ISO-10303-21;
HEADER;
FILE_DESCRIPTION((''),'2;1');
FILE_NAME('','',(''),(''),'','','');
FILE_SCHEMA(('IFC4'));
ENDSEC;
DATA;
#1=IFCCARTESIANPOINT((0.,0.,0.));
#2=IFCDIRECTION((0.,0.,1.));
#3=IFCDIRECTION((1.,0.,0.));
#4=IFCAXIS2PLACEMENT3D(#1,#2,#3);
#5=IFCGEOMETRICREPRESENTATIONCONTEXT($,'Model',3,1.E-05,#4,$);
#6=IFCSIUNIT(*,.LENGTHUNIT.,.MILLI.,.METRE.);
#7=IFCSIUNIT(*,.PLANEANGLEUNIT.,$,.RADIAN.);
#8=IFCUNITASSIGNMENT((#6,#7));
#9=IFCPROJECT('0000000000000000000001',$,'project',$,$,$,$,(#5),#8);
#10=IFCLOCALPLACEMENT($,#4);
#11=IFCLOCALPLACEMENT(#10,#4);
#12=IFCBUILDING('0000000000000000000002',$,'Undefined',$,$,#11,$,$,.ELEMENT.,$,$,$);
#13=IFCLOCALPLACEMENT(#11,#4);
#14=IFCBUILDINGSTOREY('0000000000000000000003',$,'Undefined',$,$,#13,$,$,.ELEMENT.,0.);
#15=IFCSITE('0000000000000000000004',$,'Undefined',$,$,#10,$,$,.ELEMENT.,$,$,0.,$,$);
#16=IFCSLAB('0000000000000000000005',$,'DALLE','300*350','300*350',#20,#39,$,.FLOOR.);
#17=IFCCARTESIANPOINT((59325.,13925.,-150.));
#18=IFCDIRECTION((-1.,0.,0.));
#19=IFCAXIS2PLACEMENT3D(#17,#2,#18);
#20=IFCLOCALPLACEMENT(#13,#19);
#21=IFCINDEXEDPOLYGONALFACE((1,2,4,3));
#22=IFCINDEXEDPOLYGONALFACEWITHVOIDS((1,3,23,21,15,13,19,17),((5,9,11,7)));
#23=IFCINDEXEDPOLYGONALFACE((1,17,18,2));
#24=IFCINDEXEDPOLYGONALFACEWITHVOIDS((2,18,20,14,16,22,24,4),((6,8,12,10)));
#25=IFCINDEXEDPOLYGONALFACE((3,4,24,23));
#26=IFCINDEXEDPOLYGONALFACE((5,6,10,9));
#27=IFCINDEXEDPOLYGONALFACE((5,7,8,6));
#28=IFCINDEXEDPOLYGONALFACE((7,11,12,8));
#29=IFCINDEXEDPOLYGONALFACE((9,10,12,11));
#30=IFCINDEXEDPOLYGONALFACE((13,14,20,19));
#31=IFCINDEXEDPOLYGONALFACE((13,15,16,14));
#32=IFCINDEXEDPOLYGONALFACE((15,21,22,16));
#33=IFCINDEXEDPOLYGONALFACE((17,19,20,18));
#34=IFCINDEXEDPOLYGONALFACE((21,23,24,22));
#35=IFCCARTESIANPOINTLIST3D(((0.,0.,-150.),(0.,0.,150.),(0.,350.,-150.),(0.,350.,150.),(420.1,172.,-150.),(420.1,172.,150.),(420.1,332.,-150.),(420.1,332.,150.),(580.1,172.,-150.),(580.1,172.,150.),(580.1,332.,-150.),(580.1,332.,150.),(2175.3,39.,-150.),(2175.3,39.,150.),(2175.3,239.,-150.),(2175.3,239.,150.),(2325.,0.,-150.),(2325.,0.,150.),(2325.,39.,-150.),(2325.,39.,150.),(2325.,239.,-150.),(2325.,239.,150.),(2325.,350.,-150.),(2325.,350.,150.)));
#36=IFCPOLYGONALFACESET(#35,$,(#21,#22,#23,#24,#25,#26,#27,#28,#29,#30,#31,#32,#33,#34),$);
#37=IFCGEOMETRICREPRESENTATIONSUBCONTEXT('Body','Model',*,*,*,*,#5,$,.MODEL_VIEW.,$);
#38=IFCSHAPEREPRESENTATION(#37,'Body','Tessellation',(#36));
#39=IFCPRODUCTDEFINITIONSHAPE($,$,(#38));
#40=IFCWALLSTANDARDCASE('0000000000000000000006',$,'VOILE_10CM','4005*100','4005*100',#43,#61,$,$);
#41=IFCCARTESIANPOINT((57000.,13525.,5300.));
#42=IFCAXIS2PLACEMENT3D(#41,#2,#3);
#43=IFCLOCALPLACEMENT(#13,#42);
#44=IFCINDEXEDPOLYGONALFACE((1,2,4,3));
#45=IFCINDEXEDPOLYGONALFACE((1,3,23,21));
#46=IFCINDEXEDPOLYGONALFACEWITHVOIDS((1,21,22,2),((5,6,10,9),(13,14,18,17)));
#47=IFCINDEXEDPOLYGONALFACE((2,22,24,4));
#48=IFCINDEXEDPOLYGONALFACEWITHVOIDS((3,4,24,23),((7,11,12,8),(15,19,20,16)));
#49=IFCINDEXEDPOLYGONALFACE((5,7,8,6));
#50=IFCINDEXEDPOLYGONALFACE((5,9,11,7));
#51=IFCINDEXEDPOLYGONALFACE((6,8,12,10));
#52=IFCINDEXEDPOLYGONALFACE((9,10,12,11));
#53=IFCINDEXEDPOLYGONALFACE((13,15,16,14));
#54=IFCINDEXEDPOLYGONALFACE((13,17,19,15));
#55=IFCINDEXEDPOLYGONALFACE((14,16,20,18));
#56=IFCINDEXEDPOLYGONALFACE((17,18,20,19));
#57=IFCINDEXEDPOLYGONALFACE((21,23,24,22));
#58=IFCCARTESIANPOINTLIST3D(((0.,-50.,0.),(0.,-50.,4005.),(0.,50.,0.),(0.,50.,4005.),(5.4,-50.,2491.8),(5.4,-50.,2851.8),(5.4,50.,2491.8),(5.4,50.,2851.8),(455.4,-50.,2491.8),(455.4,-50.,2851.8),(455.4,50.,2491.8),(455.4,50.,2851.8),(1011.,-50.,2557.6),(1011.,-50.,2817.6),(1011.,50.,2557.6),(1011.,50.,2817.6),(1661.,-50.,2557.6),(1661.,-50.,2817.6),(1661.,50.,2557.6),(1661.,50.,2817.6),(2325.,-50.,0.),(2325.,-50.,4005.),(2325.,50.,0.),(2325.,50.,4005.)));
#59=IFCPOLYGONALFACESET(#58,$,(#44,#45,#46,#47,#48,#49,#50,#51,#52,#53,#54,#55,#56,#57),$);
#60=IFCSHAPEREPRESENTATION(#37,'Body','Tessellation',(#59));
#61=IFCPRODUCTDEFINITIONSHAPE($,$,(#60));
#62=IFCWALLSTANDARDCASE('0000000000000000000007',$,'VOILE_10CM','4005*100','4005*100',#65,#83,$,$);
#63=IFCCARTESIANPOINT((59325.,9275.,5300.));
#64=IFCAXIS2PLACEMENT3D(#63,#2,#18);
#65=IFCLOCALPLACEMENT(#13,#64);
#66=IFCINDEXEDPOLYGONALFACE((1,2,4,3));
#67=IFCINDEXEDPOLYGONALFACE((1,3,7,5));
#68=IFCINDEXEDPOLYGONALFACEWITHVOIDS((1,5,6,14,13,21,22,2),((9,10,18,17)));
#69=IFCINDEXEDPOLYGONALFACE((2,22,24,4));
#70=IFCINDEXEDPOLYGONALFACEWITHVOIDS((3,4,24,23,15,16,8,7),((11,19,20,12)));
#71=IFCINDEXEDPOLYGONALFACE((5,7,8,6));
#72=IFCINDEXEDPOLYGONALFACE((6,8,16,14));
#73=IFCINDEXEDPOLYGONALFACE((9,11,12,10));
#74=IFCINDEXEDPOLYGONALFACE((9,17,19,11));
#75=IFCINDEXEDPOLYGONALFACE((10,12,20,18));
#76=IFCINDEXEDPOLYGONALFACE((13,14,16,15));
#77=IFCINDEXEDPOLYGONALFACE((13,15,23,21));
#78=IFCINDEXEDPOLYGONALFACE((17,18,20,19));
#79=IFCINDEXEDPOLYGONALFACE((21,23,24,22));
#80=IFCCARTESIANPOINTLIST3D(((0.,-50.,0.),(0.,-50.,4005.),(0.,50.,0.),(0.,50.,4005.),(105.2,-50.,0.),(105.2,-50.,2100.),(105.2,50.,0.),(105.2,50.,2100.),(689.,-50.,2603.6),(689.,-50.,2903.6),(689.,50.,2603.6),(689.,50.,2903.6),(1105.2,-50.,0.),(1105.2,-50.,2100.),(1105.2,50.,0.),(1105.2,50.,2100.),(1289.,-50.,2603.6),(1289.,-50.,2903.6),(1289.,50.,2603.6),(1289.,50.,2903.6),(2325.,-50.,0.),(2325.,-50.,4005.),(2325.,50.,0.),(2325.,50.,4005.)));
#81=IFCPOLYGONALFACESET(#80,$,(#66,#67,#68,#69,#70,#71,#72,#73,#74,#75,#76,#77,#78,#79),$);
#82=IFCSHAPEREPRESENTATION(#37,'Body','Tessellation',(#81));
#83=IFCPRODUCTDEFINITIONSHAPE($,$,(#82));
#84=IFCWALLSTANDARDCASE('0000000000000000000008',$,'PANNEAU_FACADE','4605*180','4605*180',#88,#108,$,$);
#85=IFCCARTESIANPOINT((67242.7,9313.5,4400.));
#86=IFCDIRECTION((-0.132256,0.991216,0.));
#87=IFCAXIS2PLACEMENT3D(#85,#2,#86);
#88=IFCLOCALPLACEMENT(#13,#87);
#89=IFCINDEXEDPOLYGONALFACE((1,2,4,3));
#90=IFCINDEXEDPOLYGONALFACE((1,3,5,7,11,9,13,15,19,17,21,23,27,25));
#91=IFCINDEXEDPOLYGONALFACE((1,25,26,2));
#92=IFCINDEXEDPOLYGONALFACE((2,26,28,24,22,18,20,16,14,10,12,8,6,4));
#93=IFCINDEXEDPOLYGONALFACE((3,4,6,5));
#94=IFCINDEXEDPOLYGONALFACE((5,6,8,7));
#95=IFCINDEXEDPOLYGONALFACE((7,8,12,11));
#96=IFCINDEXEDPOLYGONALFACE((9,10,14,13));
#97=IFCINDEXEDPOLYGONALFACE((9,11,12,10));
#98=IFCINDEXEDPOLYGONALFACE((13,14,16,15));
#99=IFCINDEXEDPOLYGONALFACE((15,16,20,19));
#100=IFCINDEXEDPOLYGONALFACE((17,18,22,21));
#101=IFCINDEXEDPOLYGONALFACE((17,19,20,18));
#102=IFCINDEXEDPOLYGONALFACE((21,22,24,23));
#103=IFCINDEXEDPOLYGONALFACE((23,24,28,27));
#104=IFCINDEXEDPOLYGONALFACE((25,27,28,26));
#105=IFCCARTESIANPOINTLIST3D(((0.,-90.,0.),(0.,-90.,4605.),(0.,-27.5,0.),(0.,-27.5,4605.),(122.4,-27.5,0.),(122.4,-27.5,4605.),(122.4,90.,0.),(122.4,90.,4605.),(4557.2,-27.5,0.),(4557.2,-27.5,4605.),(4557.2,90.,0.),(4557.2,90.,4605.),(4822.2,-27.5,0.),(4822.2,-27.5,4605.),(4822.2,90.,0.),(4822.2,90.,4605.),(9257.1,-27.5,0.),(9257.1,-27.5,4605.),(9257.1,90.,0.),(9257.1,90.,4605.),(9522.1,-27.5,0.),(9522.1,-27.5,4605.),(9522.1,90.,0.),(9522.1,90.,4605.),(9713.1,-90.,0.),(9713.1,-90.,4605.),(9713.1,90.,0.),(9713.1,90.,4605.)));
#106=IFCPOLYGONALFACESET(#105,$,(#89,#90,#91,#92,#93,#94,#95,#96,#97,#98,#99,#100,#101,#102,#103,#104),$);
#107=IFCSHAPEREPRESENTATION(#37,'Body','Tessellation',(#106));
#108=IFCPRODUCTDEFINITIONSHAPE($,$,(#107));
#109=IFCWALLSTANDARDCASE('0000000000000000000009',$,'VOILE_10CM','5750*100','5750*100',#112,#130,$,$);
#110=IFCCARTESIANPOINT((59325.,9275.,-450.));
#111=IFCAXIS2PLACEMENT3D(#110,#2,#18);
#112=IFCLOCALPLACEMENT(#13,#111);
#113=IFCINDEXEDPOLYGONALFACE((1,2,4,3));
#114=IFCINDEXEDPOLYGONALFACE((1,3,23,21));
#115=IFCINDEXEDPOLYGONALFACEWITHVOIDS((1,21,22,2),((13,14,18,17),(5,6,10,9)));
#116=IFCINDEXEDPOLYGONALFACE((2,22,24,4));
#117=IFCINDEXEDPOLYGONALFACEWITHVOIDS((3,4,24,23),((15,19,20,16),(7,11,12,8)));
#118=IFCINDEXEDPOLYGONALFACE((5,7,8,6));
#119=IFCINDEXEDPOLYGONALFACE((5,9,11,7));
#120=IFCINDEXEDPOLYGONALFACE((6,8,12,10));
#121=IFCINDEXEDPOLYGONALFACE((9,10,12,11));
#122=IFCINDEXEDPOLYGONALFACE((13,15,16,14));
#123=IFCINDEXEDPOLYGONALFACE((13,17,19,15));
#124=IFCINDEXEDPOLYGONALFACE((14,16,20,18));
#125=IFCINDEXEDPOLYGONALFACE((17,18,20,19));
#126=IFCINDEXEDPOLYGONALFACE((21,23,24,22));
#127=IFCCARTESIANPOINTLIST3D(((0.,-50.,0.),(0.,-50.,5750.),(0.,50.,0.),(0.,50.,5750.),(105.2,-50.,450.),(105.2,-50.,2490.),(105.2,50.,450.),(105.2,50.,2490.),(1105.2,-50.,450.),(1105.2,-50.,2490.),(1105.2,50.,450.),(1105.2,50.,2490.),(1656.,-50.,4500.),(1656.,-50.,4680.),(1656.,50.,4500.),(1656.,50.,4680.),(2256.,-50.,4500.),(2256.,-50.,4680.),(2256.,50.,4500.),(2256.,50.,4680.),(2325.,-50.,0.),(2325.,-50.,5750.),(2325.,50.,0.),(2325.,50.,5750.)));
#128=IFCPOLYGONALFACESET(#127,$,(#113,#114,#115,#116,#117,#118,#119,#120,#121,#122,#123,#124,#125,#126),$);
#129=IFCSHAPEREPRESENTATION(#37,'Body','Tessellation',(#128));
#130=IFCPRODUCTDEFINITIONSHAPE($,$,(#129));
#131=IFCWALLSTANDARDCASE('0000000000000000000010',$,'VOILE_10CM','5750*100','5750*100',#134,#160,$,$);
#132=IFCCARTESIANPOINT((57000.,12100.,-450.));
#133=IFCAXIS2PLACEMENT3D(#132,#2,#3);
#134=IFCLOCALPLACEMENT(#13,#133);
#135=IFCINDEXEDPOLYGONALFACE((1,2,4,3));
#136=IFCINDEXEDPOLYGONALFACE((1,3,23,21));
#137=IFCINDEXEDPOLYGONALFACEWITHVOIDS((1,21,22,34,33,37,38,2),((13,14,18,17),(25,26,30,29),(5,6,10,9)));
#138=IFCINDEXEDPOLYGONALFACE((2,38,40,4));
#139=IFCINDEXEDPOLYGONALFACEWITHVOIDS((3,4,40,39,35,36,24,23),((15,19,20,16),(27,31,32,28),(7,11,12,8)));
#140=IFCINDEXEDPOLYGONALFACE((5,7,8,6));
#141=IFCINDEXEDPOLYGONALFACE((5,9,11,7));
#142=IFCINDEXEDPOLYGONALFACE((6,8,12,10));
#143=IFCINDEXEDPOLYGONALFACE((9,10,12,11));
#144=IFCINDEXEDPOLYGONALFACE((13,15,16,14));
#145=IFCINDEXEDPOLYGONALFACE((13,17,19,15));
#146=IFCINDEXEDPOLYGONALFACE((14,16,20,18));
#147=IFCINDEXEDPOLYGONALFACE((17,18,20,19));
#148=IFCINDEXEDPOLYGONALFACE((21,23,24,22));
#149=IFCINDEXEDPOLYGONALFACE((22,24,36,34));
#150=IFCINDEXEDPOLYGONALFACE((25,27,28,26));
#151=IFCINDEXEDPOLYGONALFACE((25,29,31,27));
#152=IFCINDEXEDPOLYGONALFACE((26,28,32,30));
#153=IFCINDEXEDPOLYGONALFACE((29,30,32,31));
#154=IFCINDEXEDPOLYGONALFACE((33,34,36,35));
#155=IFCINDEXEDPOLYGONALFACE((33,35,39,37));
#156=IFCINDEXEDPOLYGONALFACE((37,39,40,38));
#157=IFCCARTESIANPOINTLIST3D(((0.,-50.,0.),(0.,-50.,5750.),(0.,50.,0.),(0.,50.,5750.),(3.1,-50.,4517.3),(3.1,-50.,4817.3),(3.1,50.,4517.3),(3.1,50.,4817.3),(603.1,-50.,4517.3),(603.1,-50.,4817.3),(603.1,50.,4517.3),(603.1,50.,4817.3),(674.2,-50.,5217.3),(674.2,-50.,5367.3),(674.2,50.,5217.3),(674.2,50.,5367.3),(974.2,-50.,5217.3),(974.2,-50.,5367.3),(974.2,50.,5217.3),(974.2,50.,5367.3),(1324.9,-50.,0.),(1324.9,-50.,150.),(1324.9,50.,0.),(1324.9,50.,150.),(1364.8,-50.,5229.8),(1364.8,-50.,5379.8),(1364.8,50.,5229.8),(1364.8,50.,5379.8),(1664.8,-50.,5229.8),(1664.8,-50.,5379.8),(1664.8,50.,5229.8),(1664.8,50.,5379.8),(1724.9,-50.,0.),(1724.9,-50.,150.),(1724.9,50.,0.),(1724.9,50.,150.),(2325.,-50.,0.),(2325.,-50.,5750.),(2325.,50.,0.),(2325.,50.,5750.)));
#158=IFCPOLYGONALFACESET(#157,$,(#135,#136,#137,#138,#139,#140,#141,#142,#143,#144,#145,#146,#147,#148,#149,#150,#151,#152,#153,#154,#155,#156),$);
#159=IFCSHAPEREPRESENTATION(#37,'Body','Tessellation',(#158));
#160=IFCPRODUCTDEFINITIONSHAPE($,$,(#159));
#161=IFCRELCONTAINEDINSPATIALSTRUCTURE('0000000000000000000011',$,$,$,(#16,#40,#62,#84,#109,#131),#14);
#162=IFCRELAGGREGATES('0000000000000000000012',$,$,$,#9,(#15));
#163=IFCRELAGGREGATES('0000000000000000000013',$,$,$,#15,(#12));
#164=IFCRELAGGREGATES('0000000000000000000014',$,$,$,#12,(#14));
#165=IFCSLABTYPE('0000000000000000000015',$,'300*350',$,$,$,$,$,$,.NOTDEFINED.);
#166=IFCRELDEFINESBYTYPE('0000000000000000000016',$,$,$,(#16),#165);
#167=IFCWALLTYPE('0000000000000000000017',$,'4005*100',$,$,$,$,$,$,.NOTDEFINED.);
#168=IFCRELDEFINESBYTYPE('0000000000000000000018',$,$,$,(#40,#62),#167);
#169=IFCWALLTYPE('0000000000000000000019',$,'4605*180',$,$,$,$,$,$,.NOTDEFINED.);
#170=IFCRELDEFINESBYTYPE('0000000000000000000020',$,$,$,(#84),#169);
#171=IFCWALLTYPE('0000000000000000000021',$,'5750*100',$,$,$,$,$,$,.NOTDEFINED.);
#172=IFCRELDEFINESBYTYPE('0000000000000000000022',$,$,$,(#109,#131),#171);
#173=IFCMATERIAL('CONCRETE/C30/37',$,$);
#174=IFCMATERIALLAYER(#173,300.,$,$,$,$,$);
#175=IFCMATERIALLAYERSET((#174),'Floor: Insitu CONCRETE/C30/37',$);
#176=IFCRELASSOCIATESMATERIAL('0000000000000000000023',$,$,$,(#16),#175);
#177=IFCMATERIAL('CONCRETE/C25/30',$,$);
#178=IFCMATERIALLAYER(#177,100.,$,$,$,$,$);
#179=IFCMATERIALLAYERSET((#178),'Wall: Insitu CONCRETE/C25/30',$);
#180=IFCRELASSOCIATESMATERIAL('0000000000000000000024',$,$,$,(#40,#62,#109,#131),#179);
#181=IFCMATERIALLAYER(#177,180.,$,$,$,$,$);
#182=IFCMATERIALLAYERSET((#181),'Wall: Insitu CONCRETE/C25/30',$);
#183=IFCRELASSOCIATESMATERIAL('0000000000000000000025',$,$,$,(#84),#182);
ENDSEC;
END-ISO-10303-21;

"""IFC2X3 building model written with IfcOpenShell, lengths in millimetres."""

from ifc_helpers import new_model, si_unit, frame, frame_2d, origin_with_axes, origin_2d_with_axis, place, context, subcontext, project, spatial, polyline, rectangle, outline, extrude, boolean, material, layer, layer_set, layer_usage, type_object, element, save


model = new_model("IFC2X3")

# Units and contexts
model_context = context("Model", 3, precision=1e-05, world=origin_with_axes())
body_context = subcontext(model_context, "Body", "Model", "MODEL_VIEW")
ifc_project = project(units=[si_unit("LENGTHUNIT", "METRE", prefix="MILLI"), si_unit("PLANEANGLEUNIT", "RADIAN")], contexts=[model_context])

# Site, building, storey
site_placement = place(None, origin_with_axes())
site = spatial("IfcSite", under=ifc_project, at=site_placement, Name="Undefined", CompositionType="ELEMENT", RefElevation=0.0)
building_placement = place(site_placement, origin_with_axes())
building = spatial("IfcBuilding", under=site, at=building_placement, Name="Undefined", CompositionType="ELEMENT")
storey_placement = place(building_placement, origin_with_axes())
storey = spatial("IfcBuildingStorey", under=building, at=storey_placement, Name="Undefined", CompositionType="ELEMENT", Elevation=0.0)

# Shared definitions
ifc_material_1 = material(Name="CONCRETE/C25/30")

# Slab
ifc_material_2 = material(Name="CONCRETE/C30/37")
ifc_layer_1 = layer(ifc_material_2, 300.0)
ifc_layer_set_1 = layer_set([ifc_layer_1], Name="Floor: Insitu CONCRETE/C30/37")
ifc_layer_usage_1 = layer_usage(ifc_layer_set_1, "AXIS3", "POSITIVE", -150.0)
slab_type_1 = type_object("IfcSlabType", Name="300*350", PredefinedType="NOTDEFINED")
slab_1_placement = place(storey_placement, frame((59325.0, 13925.0, -150.0), z_axis=(0.0, 0.0, 1.0), x_axis=(-1.0, 0.0, 0.0)))
element("IfcSlab", 1, at=slab_1_placement, inside=storey, type_object=slab_type_1, material=ifc_layer_usage_1, Name="DALLE", Description="300*350", ObjectType="300*350", PredefinedType="FLOOR", context=body_context, shape_type="CSG", body=[
    boolean("DIFFERENCE", boolean("DIFFERENCE", extrude(outline(polyline([(0.0, 0.0), (2325.0, 0.0), (2325.0, 350.0), (0.0, 350.0), (0.0, 0.0)])), frame((0.0, 0.0, -150.0), z_axis=(0.0, 0.0, 1.0), x_axis=(1.0, 0.0, 0.0)), (0.0, 0.0, 1.0), 300.0), extrude(rectangle(XDim=160.0, YDim=160.0, at=origin_2d_with_axis()), frame((500.1, 252.0, 160.0), z_axis=(0.0, 0.0, -1.0), x_axis=(-1.0, 0.0, 0.0)), (0.0, 0.0, 1.0), 320.0)), extrude(rectangle(XDim=150.0, YDim=200.0, at=origin_2d_with_axis()), frame((2250.3, 139.0, 160.0), z_axis=(0.0, 0.0, -1.0), x_axis=(-1.0, 0.0, 0.0)), (0.0, 0.0, 1.0), 320.0)),
])

# Walls
ifc_layer_2 = layer(ifc_material_1, 180.0)
ifc_layer_set_2 = layer_set([ifc_layer_2], Name="Wall: Insitu CONCRETE/C25/30")
ifc_layer_3 = layer(ifc_material_1, 100.0)
ifc_layer_set_3 = layer_set([ifc_layer_3], Name="Wall: Insitu CONCRETE/C25/30")
ifc_layer_usage_2 = layer_usage(ifc_layer_set_3, "AXIS2", "POSITIVE", -50.0)
wall_type_1 = type_object("IfcWallType", Name="4005*100", PredefinedType="NOTDEFINED")
wall_1_placement = place(storey_placement, frame((57000.0, 13525.0, 5300.0), z_axis=(0.0, 0.0, 1.0), x_axis=(1.0, 0.0, 0.0)))
element("IfcWallStandardCase", 2, at=wall_1_placement, inside=storey, type_object=wall_type_1, material=ifc_layer_usage_2, Name="VOILE_10CM", Description="4005*100", ObjectType="4005*100", context=body_context, shape_type="CSG", body=[
    boolean("DIFFERENCE", boolean("DIFFERENCE", extrude(rectangle(XDim=2325.0, YDim=100.0, at=frame_2d((0.0, 1162.5), x_axis=(0.0, -1.0))), frame((0.0, 0.0, 0.0), z_axis=(0.0, 0.0, 1.0), x_axis=(0.0, -1.0, 0.0)), (0.0, 0.0, 1.0), 4005.0), extrude(rectangle(XDim=450.0, YDim=360.0, at=origin_2d_with_axis()), frame((230.4, -60.0, 2671.8), z_axis=(0.0, 1.0, 0.0), x_axis=(-1.0, 0.0, 0.0)), (0.0, 0.0, 1.0), 120.0)), extrude(rectangle(XDim=650.0, YDim=260.0, at=origin_2d_with_axis()), frame((1336.0, -60.0, 2687.6), z_axis=(0.0, 1.0, 0.0), x_axis=(-1.0, 0.0, 0.0)), (0.0, 0.0, 1.0), 120.0)),
])
ifc_layer_usage_3 = layer_usage(ifc_layer_set_3, "AXIS2", "POSITIVE", -50.0)
wall_2_placement = place(storey_placement, frame((59325.0, 9275.0, 5300.0), z_axis=(0.0, 0.0, 1.0), x_axis=(-1.0, 0.0, 0.0)))
element("IfcWallStandardCase", 3, at=wall_2_placement, inside=storey, type_object=wall_type_1, material=ifc_layer_usage_3, Name="VOILE_10CM", Description="4005*100", ObjectType="4005*100", context=body_context, shape_type="CSG", body=[
    boolean("DIFFERENCE", boolean("DIFFERENCE", extrude(rectangle(XDim=2325.0, YDim=100.0, at=frame_2d((0.0, 1162.5), x_axis=(0.0, -1.0))), frame((0.0, 0.0, 0.0), z_axis=(0.0, 0.0, 1.0), x_axis=(0.0, -1.0, 0.0)), (0.0, 0.0, 1.0), 4005.0), extrude(rectangle(XDim=600.0, YDim=300.0, at=origin_2d_with_axis()), frame((989.0, -60.0, 2753.6), z_axis=(0.0, 1.0, 0.0), x_axis=(-1.0, 0.0, 0.0)), (0.0, 0.0, 1.0), 120.0)), extrude(outline(polyline([(0.0, 0.0), (2100.0, 0.0), (2100.0, 1000.0), (0.0, 1000.0), (0.0, 0.0)])), frame((1105.2, -60.0, 2100.0), z_axis=(0.0, 1.0, 0.0), x_axis=(0.0, 0.0, -1.0)), (0.0, 0.0, 1.0), 120.0)),
])
ifc_layer_usage_4 = layer_usage(ifc_layer_set_2, "AXIS2", "POSITIVE", -90.0)
wall_type_2 = type_object("IfcWallType", Name="4605*180", PredefinedType="NOTDEFINED")
wall_3_placement = place(storey_placement, frame((67242.7, 9313.5, 4400.0), z_axis=(0.0, 0.0, 1.0), x_axis=(-0.132256, 0.991216, 0.0)))
element("IfcWallStandardCase", 4, at=wall_3_placement, inside=storey, type_object=wall_type_2, material=ifc_layer_usage_4, Name="PANNEAU_FACADE", Description="4605*180", ObjectType="4605*180", context=body_context, shape_type="CSG", body=[
    boolean("DIFFERENCE", boolean("DIFFERENCE", boolean("DIFFERENCE", extrude(rectangle(XDim=9713.1, YDim=180.0, at=frame_2d((0.0, 4856.6), x_axis=(0.0, -1.0))), frame((0.0, 0.0, 0.0), z_axis=(0.0, 0.0, 1.0), x_axis=(0.0, -1.0, 0.0)), (0.0, 0.0, 1.0), 4605.0), extrude(rectangle(XDim=265.0, YDim=265.0, at=origin_2d_with_axis()), frame((-10.1, 105.0, 4605.0), z_axis=(0.0, 0.0, -1.0), x_axis=(-1.0, 0.0, 0.0)), (0.0, 0.0, 1.0), 4605.0)), extrude(rectangle(XDim=265.0, YDim=265.0, at=origin_2d_with_axis()), frame((4689.7, 105.0, 4605.0), z_axis=(0.0, 0.0, -1.0), x_axis=(-1.0, 0.0, 0.0)), (0.0, 0.0, 1.0), 4605.0)), extrude(rectangle(XDim=265.0, YDim=265.0, at=origin_2d_with_axis()), frame((9389.6, 105.0, 4605.0), z_axis=(0.0, 0.0, -1.0), x_axis=(-1.0, 0.0, 0.0)), (0.0, 0.0, 1.0), 4605.0)),
])
wall_type_3 = type_object("IfcWallType", Name="5750*100", PredefinedType="NOTDEFINED")
ifc_layer_usage_5 = layer_usage(ifc_layer_set_3, "AXIS2", "POSITIVE", -50.0)
wall_4_placement = place(storey_placement, frame((59325.0, 9275.0, -450.0), z_axis=(0.0, 0.0, 1.0), x_axis=(-1.0, 0.0, 0.0)))
element("IfcWallStandardCase", 5, at=wall_4_placement, inside=storey, type_object=wall_type_3, material=ifc_layer_usage_5, Name="VOILE_10CM", Description="5750*100", ObjectType="5750*100", context=body_context, shape_type="CSG", body=[
    boolean("DIFFERENCE", boolean("DIFFERENCE", boolean("DIFFERENCE", extrude(rectangle(XDim=2325.0, YDim=100.0, at=frame_2d((0.0, 1162.5), x_axis=(0.0, -1.0))), frame((0.0, 0.0, 0.0), z_axis=(0.0, 0.0, 1.0), x_axis=(0.0, -1.0, 0.0)), (0.0, 0.0, 1.0), 5750.0), extrude(rectangle(XDim=600.0, YDim=180.0, at=origin_2d_with_axis()), frame((1956.0, -60.0, 4590.0), z_axis=(0.0, 1.0, 0.0), x_axis=(-1.0, 0.0, 0.0)), (0.0, 0.0, 1.0), 120.0)), extrude(outline(polyline([(0.0, 0.0), (2040.0, 0.0), (2040.0, 1000.0), (0.0, 1000.0), (0.0, 0.0)])), frame((1105.2, -60.0, 2490.0), z_axis=(0.0, 1.0, 0.0), x_axis=(0.0, 0.0, -1.0)), (0.0, 0.0, 1.0), 120.0)), extrude(rectangle(XDim=1000.0, YDim=105.1, at=origin_2d_with_axis()), frame((605.2, 150.0, -52.5), z_axis=(0.0, -1.0, 0.0), x_axis=(1.0, 0.0, 0.0)), (0.0, 0.0, 1.0), 137.4)),
])
ifc_layer_usage_6 = layer_usage(ifc_layer_set_3, "AXIS2", "POSITIVE", -50.0)
wall_5_placement = place(storey_placement, frame((57000.0, 12100.0, -450.0), z_axis=(0.0, 0.0, 1.0), x_axis=(1.0, 0.0, 0.0)))
element("IfcWallStandardCase", 6, at=wall_5_placement, inside=storey, type_object=wall_type_3, material=ifc_layer_usage_6, Name="VOILE_10CM", Description="5750*100", ObjectType="5750*100", context=body_context, shape_type="CSG", body=[
    boolean("DIFFERENCE", boolean("DIFFERENCE", boolean("DIFFERENCE", boolean("DIFFERENCE", extrude(rectangle(XDim=2325.0, YDim=100.0, at=frame_2d((0.0, 1162.5), x_axis=(0.0, -1.0))), frame((0.0, 0.0, 0.0), z_axis=(0.0, 0.0, 1.0), x_axis=(0.0, -1.0, 0.0)), (0.0, 0.0, 1.0), 5750.0), extrude(rectangle(XDim=300.0, YDim=150.0, at=origin_2d_with_axis()), frame((1514.8, -60.0, 5304.8), z_axis=(0.0, 1.0, 0.0), x_axis=(-1.0, 0.0, 0.0)), (0.0, 0.0, 1.0), 120.0)), extrude(rectangle(XDim=300.0, YDim=150.0, at=origin_2d_with_axis()), frame((824.2, -60.0, 5292.3), z_axis=(0.0, 1.0, 0.0), x_axis=(-1.0, 0.0, 0.0)), (0.0, 0.0, 1.0), 120.0)), extrude(rectangle(XDim=400.0, YDim=150.0, at=origin_2d_with_axis()), frame((1524.9, -60.0, 75.0), z_axis=(0.0, 1.0, 0.0), x_axis=(-1.0, 0.0, 0.0)), (0.0, 0.0, 1.0), 120.0)), extrude(rectangle(XDim=600.0, YDim=300.0, at=origin_2d_with_axis()), frame((303.1, -60.0, 4667.3), z_axis=(0.0, 1.0, 0.0), x_axis=(-1.0, 0.0, 0.0)), (0.0, 0.0, 1.0), 120.0)),
])

save(model, "model.ifc")
